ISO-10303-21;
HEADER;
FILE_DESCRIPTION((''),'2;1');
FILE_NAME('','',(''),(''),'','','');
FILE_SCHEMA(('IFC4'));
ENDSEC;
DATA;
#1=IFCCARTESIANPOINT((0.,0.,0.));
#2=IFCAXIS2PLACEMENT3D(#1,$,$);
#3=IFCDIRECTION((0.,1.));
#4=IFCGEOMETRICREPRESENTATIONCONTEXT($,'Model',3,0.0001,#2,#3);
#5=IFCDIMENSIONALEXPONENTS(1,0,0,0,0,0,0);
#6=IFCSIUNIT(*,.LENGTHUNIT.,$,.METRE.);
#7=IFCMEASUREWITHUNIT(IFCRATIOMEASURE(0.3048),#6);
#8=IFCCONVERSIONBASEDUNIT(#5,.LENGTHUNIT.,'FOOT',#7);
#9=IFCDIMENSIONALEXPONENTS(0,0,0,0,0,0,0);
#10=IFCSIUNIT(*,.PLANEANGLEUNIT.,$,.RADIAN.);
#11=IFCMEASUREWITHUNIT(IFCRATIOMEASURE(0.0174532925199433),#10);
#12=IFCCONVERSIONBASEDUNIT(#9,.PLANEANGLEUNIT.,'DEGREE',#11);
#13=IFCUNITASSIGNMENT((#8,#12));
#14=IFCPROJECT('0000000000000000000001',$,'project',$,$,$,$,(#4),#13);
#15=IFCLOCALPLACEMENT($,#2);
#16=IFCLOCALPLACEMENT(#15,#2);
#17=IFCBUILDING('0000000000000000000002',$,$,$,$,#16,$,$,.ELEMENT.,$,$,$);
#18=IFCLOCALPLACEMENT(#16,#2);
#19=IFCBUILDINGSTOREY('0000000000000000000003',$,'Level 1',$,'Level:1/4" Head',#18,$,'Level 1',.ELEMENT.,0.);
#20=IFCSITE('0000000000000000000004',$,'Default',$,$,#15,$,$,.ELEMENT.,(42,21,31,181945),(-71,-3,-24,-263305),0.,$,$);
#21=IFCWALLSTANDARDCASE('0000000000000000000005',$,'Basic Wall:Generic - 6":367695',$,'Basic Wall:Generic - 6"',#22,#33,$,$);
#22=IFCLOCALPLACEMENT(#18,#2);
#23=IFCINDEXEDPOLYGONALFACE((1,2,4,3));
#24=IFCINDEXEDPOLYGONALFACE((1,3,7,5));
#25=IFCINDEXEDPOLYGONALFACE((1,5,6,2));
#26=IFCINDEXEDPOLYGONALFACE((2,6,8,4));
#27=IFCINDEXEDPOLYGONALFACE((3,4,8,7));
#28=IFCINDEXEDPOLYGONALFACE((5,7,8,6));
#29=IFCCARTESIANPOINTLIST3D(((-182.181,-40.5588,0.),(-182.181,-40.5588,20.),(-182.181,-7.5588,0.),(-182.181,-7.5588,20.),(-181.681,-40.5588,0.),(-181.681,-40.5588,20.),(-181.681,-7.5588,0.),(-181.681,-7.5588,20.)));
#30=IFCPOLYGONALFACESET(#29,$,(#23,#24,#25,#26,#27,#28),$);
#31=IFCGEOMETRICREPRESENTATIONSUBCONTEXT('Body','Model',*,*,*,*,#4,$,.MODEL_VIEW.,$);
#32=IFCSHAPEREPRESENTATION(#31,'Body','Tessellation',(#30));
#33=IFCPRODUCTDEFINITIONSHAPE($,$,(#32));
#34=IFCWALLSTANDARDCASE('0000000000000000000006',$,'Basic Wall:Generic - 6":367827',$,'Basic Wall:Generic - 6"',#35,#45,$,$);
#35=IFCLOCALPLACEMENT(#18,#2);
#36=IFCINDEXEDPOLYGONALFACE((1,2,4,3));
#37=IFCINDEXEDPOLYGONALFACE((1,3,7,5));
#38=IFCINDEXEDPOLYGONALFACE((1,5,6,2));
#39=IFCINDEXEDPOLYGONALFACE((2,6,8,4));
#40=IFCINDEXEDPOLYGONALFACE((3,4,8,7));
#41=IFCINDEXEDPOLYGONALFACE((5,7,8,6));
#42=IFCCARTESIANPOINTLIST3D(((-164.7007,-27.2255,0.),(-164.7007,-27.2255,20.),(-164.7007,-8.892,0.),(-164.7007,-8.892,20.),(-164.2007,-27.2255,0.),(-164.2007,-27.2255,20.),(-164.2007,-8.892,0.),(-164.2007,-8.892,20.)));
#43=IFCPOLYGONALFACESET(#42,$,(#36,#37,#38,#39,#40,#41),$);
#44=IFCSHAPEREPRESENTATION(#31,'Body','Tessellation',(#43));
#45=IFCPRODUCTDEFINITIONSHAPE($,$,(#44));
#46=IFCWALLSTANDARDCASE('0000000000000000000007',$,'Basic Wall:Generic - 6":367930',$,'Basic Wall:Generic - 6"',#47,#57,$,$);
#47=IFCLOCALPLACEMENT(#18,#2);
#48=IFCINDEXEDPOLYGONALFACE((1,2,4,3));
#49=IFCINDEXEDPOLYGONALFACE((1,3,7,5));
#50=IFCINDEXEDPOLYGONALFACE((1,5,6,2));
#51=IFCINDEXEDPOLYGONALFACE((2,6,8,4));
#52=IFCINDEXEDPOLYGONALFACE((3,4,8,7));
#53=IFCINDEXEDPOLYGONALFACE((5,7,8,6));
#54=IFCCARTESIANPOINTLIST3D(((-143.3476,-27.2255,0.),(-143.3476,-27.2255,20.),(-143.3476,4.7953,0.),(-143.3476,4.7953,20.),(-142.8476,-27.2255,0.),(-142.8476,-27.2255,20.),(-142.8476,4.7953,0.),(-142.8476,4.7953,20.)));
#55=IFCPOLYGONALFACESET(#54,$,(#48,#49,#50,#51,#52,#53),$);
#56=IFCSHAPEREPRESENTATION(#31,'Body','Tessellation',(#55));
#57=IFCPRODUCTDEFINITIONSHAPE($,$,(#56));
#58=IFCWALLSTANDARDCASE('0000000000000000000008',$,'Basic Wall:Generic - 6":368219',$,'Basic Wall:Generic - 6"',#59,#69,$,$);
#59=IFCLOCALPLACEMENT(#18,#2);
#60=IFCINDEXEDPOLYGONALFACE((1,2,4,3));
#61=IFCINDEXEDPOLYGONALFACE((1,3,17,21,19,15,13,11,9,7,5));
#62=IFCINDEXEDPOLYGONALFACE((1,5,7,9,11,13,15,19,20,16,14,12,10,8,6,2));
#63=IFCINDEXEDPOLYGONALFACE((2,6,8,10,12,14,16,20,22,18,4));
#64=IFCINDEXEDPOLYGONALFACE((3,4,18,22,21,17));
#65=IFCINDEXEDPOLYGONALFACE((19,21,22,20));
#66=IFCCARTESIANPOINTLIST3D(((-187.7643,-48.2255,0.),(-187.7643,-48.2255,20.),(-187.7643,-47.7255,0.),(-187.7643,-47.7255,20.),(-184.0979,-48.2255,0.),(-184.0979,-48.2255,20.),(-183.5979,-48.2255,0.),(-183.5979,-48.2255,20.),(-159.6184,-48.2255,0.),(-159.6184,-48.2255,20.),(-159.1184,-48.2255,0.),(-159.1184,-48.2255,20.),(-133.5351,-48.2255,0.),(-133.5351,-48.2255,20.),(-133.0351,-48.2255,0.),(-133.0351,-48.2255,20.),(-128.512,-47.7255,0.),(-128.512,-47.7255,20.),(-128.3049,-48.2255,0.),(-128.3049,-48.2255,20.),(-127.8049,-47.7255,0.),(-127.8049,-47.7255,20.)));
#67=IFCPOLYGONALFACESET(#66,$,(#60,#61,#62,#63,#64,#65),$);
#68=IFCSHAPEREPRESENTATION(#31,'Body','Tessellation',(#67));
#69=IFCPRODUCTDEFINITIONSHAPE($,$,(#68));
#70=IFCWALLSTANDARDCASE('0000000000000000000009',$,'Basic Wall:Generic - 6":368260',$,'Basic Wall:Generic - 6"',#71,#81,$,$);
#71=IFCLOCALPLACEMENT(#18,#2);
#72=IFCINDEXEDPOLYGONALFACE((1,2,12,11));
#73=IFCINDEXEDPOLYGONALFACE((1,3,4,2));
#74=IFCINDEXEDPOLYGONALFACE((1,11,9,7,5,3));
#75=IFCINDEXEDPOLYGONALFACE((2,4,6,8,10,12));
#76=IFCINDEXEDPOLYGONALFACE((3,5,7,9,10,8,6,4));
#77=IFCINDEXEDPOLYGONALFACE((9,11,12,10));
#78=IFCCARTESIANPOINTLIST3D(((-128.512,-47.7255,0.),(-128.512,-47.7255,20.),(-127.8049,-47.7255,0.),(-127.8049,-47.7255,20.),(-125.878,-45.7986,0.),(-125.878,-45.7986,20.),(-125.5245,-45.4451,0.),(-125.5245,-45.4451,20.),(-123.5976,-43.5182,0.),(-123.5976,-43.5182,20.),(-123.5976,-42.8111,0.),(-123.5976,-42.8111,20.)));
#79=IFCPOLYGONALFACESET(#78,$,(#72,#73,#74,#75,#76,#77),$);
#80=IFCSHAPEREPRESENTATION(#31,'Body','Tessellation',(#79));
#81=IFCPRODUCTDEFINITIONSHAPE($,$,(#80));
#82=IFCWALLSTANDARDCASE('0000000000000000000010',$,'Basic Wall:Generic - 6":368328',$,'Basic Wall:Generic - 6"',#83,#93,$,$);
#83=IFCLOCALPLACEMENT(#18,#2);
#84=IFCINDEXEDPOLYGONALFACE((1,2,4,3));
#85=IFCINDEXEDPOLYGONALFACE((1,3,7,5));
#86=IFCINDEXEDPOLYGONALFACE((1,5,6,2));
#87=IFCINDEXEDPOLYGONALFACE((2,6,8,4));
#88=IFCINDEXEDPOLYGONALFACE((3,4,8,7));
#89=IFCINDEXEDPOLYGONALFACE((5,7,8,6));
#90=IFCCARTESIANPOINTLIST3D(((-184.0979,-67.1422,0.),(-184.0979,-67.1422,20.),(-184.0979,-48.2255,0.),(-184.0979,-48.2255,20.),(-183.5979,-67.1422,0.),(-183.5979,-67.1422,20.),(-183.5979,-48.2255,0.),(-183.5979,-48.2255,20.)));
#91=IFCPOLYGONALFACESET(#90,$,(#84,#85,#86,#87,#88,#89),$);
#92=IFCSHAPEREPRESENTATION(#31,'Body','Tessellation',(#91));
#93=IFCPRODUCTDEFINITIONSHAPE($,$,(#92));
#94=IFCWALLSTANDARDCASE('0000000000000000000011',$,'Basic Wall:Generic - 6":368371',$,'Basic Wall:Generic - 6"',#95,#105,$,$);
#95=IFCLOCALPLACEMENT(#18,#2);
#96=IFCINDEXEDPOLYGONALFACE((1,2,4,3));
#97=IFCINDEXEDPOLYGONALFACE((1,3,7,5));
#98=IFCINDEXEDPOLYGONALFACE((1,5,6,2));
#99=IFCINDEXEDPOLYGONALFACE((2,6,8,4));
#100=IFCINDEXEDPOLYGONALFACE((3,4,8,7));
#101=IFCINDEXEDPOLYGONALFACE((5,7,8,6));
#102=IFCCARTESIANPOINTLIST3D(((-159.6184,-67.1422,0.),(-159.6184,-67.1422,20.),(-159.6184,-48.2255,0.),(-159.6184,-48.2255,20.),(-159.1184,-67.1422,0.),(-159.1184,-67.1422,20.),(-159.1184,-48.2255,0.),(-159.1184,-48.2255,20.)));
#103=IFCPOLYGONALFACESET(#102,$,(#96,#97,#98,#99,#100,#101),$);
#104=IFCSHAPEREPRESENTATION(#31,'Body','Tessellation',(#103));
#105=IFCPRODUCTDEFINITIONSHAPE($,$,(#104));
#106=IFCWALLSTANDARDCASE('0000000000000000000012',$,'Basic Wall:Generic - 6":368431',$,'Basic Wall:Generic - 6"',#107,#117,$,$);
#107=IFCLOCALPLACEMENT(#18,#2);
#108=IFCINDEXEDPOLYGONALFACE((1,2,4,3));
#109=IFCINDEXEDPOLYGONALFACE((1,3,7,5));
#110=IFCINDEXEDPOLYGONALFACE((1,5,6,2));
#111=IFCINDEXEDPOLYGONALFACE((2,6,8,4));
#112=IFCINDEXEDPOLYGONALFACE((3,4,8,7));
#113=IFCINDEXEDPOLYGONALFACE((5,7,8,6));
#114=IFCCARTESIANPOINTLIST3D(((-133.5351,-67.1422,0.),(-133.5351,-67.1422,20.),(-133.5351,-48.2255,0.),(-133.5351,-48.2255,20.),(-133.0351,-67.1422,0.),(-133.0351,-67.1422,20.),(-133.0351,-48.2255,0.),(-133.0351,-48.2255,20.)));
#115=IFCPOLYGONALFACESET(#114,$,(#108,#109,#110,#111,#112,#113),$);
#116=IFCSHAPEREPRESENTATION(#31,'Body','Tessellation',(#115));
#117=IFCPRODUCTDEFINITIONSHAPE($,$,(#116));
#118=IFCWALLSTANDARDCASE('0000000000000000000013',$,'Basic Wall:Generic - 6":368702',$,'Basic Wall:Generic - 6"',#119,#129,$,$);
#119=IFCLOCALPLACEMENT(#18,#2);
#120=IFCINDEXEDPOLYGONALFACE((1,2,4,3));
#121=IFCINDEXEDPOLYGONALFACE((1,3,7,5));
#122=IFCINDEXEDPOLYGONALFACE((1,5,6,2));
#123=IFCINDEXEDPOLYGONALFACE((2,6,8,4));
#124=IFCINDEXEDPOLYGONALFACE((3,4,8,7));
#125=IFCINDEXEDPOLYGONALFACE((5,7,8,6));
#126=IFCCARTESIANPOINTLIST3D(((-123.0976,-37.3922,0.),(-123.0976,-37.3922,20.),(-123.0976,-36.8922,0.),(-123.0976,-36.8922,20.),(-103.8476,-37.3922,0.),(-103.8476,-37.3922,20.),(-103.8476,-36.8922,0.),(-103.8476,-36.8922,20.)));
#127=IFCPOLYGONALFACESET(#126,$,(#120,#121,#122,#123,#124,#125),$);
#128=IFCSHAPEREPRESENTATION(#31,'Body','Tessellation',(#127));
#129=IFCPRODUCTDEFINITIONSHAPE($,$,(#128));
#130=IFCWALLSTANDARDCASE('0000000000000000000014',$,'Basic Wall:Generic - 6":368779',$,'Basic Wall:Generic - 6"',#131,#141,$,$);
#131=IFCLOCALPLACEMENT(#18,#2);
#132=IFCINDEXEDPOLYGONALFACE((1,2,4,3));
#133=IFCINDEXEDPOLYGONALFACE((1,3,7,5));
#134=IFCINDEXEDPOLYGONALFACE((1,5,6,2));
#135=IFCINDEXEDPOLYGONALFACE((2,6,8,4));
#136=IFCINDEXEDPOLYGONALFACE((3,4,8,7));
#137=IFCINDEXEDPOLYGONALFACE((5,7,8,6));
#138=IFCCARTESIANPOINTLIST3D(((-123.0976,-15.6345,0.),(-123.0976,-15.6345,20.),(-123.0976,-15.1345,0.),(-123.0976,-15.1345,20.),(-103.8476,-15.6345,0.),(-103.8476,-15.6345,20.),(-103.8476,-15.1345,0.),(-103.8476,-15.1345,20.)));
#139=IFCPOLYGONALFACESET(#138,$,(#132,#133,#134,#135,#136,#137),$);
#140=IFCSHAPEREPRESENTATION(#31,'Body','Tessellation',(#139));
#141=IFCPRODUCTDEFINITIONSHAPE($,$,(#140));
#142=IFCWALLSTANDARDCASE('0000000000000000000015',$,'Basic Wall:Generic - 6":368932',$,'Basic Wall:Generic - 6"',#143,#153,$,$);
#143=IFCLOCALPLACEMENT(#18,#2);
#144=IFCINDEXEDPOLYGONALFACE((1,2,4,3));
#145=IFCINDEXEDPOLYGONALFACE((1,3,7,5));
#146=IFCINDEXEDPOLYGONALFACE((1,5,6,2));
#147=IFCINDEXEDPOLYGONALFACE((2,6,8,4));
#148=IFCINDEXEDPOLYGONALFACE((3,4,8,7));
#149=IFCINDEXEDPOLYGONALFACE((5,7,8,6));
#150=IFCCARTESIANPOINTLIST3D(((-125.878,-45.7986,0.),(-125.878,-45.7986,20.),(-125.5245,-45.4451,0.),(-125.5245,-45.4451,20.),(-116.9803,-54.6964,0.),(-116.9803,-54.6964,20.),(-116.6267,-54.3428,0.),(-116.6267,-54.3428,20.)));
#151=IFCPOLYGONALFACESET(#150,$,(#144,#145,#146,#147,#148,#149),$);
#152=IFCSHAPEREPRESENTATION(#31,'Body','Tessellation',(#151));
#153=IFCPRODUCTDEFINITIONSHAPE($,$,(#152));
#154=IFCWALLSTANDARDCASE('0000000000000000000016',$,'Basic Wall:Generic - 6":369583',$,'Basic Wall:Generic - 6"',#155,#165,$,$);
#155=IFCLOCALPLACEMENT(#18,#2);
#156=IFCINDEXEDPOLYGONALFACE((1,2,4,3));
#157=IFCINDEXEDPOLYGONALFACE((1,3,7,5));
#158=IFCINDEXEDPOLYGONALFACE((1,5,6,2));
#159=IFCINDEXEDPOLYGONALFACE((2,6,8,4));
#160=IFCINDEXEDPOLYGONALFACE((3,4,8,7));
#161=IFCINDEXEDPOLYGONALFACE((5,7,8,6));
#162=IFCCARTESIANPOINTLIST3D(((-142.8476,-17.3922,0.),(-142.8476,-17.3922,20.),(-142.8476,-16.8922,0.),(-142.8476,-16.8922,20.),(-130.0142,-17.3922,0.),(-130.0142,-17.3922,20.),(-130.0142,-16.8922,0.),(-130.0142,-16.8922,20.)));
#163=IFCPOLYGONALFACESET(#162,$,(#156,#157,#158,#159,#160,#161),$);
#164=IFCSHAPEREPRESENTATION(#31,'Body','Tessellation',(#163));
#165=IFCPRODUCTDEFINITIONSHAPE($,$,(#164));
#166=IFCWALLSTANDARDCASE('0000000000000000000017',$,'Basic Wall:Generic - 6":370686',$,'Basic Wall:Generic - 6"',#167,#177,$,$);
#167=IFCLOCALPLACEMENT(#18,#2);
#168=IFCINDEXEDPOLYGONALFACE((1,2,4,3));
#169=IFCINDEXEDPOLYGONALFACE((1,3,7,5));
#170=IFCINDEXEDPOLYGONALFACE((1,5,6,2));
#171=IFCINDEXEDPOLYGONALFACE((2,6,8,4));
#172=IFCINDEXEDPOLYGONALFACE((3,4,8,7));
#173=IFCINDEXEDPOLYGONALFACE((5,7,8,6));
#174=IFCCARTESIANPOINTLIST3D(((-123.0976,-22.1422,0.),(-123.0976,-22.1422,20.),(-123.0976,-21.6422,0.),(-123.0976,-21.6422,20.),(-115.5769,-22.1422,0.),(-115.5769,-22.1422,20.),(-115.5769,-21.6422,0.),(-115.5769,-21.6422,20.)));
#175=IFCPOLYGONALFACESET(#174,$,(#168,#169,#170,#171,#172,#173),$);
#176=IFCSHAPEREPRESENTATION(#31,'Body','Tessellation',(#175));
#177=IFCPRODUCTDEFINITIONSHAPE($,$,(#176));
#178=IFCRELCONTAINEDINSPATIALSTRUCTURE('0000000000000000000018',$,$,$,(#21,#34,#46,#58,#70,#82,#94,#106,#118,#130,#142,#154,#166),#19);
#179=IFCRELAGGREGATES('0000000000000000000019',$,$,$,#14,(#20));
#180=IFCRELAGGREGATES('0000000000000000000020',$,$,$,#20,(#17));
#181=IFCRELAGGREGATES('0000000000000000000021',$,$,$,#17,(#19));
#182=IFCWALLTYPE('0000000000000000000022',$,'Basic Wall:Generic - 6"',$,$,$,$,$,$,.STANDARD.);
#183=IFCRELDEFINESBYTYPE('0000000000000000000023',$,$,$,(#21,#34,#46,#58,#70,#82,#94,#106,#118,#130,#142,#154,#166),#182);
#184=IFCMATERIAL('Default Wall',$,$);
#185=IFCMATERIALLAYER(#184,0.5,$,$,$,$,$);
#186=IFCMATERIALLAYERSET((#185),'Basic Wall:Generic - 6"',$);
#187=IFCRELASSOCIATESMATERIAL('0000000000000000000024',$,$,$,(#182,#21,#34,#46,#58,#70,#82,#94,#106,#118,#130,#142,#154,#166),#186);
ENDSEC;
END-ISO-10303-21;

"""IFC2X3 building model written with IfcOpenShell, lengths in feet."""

from ifc_helpers import new_model, entity, si_unit, converted_unit, direction, frame, frame_2d, origin, place, context, subcontext, project, spatial, polyline, rectangle, outline, extrude, material, layer, layer_set, layer_usage, type_object, element, save


model = new_model("IFC2X3")

# Units and contexts
model_context = context("Model", 3, precision=0.0001, world=origin(), true_north=direction((0.0, 1.0)))
body_context = subcontext(model_context, "Body", "Model", "MODEL_VIEW")
ifc_project = project(units=[converted_unit("LENGTHUNIT", "FOOT", entity("IfcRatioMeasure", 0.3048), si_unit("LENGTHUNIT", "METRE"), dimensions=[1, 0, 0, 0, 0, 0, 0]), converted_unit("PLANEANGLEUNIT", "DEGREE", entity("IfcRatioMeasure", 0.0174532925199433), si_unit("PLANEANGLEUNIT", "RADIAN"), dimensions=[0, 0, 0, 0, 0, 0, 0])], contexts=[model_context])

# Site, building, storey
site_placement = place(None, origin())
site = spatial("IfcSite", under=ifc_project, at=site_placement, Name="Default", CompositionType="ELEMENT", RefLatitude=(42, 21, 31, 181945), RefLongitude=(-71, -3, -24, -263305), RefElevation=0.0)
building_placement = place(site_placement, origin())
building = spatial("IfcBuilding", under=site, at=building_placement, CompositionType="ELEMENT")
storey_placement = place(building_placement, origin())
storey = spatial("IfcBuildingStorey", under=building, at=storey_placement, Name="Level 1", ObjectType="Level:1/4\" Head", LongName="Level 1", CompositionType="ELEMENT", Elevation=0.0)

# Walls
ifc_material_1 = material(Name="Default Wall")
ifc_layer_1 = layer(ifc_material_1, 0.5)
ifc_layer_set_1 = layer_set([ifc_layer_1], Name="Basic Wall:Generic - 6\"")
wall_type_1 = type_object("IfcWallType", Name="Basic Wall:Generic - 6\"", PredefinedType="STANDARD", material=ifc_layer_set_1)
ifc_layer_usage_1 = layer_usage(ifc_layer_set_1, "AXIS2", "NEGATIVE", 0.25)
wall_1_placement = place(storey_placement, frame((-181.931, -40.5588, 0.0), z_axis=(0.0, 0.0, 1.0), x_axis=(0.0, 1.0, 0.0)))
element("IfcWallStandardCase", 1, at=wall_1_placement, inside=storey, type_object=wall_type_1, material=ifc_layer_usage_1, Name="Basic Wall:Generic - 6\":367695", ObjectType="Basic Wall:Generic - 6\"", context=body_context, shape_type="SweptSolid", body=[
    extrude(rectangle(XDim=33.0, YDim=0.5, at=frame_2d((16.5, 0.0), x_axis=(-1.0, 0.0))), origin(), (0.0, 0.0, 1.0), 20.0),
])
ifc_layer_usage_2 = layer_usage(ifc_layer_set_1, "AXIS2", "NEGATIVE", 0.25)
wall_2_placement = place(storey_placement, frame((-164.4507, -27.2255, 0.0), z_axis=(0.0, 0.0, 1.0), x_axis=(0.0, 1.0, 0.0)))
element("IfcWallStandardCase", 2, at=wall_2_placement, inside=storey, type_object=wall_type_1, material=ifc_layer_usage_2, Name="Basic Wall:Generic - 6\":367827", ObjectType="Basic Wall:Generic - 6\"", context=body_context, shape_type="SweptSolid", body=[
    extrude(rectangle(XDim=18.3335, YDim=0.5, at=frame_2d((9.1667, 0.0), x_axis=(-1.0, 0.0))), origin(), (0.0, 0.0, 1.0), 20.0),
])
ifc_layer_usage_3 = layer_usage(ifc_layer_set_1, "AXIS2", "NEGATIVE", 0.25)
wall_3_placement = place(storey_placement, frame((-143.0976, -27.2255, 0.0), z_axis=(0.0, 0.0, 1.0), x_axis=(0.0, 1.0, 0.0)))
element("IfcWallStandardCase", 3, at=wall_3_placement, inside=storey, type_object=wall_type_1, material=ifc_layer_usage_3, Name="Basic Wall:Generic - 6\":367930", ObjectType="Basic Wall:Generic - 6\"", context=body_context, shape_type="SweptSolid", body=[
    extrude(rectangle(XDim=32.0208, YDim=0.5, at=frame_2d((16.0104, 0.0), x_axis=(-1.0, 0.0))), origin(), (0.0, 0.0, 1.0), 20.0),
])
ifc_layer_usage_4 = layer_usage(ifc_layer_set_1, "AXIS2", "NEGATIVE", 0.25)
wall_4_placement = place(storey_placement, frame((-187.7643, -47.9755, 0.0)))
element("IfcWallStandardCase", 4, at=wall_4_placement, inside=storey, type_object=wall_type_1, material=ifc_layer_usage_4, Name="Basic Wall:Generic - 6\":368219", ObjectType="Basic Wall:Generic - 6\"", context=body_context, shape_type="SweptSolid", body=[
    extrude(outline(polyline([(59.4594, -0.25), (59.9594, 0.25), (59.2523, 0.25), (0.0, 0.25), (0.0, -0.25), (3.6664, -0.25), (4.1664, -0.25), (28.1459, -0.25), (28.6459, -0.25), (54.2292, -0.25), (54.7292, -0.25), (59.4594, -0.25)])), origin(), (0.0, 0.0, 1.0), 20.0),
])
ifc_layer_usage_5 = layer_usage(ifc_layer_set_1, "AXIS2", "NEGATIVE", 0.25)
wall_5_placement = place(storey_placement, frame((-128.3352, -47.9023, 0.0), z_axis=(0.0, 0.0, 1.0), x_axis=(0.707107, 0.707107, 0.0)))
element("IfcWallStandardCase", 5, at=wall_5_placement, inside=storey, type_object=wall_type_1, material=ifc_layer_usage_5, Name="Basic Wall:Generic - 6\":368260", ObjectType="Basic Wall:Generic - 6\"", context=body_context, shape_type="SweptSolid", body=[
    extrude(outline(polyline([(6.4499, -0.25), (6.9499, 0.25), (0.0, 0.25), (0.5, -0.25), (3.225, -0.25), (3.725, -0.25), (6.4499, -0.25)])), origin(), (0.0, 0.0, 1.0), 20.0),
])
ifc_layer_usage_6 = layer_usage(ifc_layer_set_1, "AXIS2", "NEGATIVE", 0.25)
wall_6_placement = place(storey_placement, frame((-183.8479, -48.2255, 0.0), z_axis=(0.0, 0.0, 1.0), x_axis=(0.0, -1.0, 0.0)))
element("IfcWallStandardCase", 6, at=wall_6_placement, inside=storey, type_object=wall_type_1, material=ifc_layer_usage_6, Name="Basic Wall:Generic - 6\":368328", ObjectType="Basic Wall:Generic - 6\"", context=body_context, shape_type="SweptSolid", body=[
    extrude(rectangle(XDim=18.9167, YDim=0.5, at=frame_2d((9.4583, 0.0), x_axis=(-1.0, 0.0))), origin(), (0.0, 0.0, 1.0), 20.0),
])
ifc_layer_usage_7 = layer_usage(ifc_layer_set_1, "AXIS2", "NEGATIVE", 0.25)
wall_7_placement = place(storey_placement, frame((-159.3684, -48.2255, 0.0), z_axis=(0.0, 0.0, 1.0), x_axis=(0.0, -1.0, 0.0)))
element("IfcWallStandardCase", 7, at=wall_7_placement, inside=storey, type_object=wall_type_1, material=ifc_layer_usage_7, Name="Basic Wall:Generic - 6\":368371", ObjectType="Basic Wall:Generic - 6\"", context=body_context, shape_type="SweptSolid", body=[
    extrude(rectangle(XDim=18.9167, YDim=0.5, at=frame_2d((9.4583, 0.0), x_axis=(-1.0, 0.0))), origin(), (0.0, 0.0, 1.0), 20.0),
])
ifc_layer_usage_8 = layer_usage(ifc_layer_set_1, "AXIS2", "NEGATIVE", 0.25)
wall_8_placement = place(storey_placement, frame((-133.2851, -48.2255, 0.0), z_axis=(0.0, 0.0, 1.0), x_axis=(0.0, -1.0, 0.0)))
element("IfcWallStandardCase", 8, at=wall_8_placement, inside=storey, type_object=wall_type_1, material=ifc_layer_usage_8, Name="Basic Wall:Generic - 6\":368431", ObjectType="Basic Wall:Generic - 6\"", context=body_context, shape_type="SweptSolid", body=[
    extrude(rectangle(XDim=18.9167, YDim=0.5, at=frame_2d((9.4583, 0.0), x_axis=(-1.0, 0.0))), origin(), (0.0, 0.0, 1.0), 20.0),
])
ifc_layer_usage_9 = layer_usage(ifc_layer_set_1, "AXIS2", "NEGATIVE", 0.25)
wall_9_placement = place(storey_placement, frame((-103.8476, -37.1422, 0.0), z_axis=(0.0, 0.0, 1.0), x_axis=(-1.0, 0.0, 0.0)))
element("IfcWallStandardCase", 9, at=wall_9_placement, inside=storey, type_object=wall_type_1, material=ifc_layer_usage_9, Name="Basic Wall:Generic - 6\":368702", ObjectType="Basic Wall:Generic - 6\"", context=body_context, shape_type="SweptSolid", body=[
    extrude(rectangle(XDim=19.25, YDim=0.5, at=frame_2d((9.625, 0.0), x_axis=(-1.0, 0.0))), origin(), (0.0, 0.0, 1.0), 20.0),
])
ifc_layer_usage_10 = layer_usage(ifc_layer_set_1, "AXIS2", "NEGATIVE", 0.25)
wall_10_placement = place(storey_placement, frame((-103.8476, -15.3845, 0.0), z_axis=(0.0, 0.0, 1.0), x_axis=(-1.0, 0.0, 0.0)))
element("IfcWallStandardCase", 10, at=wall_10_placement, inside=storey, type_object=wall_type_1, material=ifc_layer_usage_10, Name="Basic Wall:Generic - 6\":368779", ObjectType="Basic Wall:Generic - 6\"", context=body_context, shape_type="SweptSolid", body=[
    extrude(rectangle(XDim=19.25, YDim=0.5, at=frame_2d((9.625, 0.0), x_axis=(-1.0, 0.0))), origin(), (0.0, 0.0, 1.0), 20.0),
])
ifc_layer_usage_11 = layer_usage(ifc_layer_set_1, "AXIS2", "NEGATIVE", 0.25)
wall_11_placement = place(storey_placement, frame((-125.7013, -45.6219, 0.0), z_axis=(0.0, 0.0, 1.0), x_axis=(0.707107, -0.707107, 0.0)))
element("IfcWallStandardCase", 11, at=wall_11_placement, inside=storey, type_object=wall_type_1, material=ifc_layer_usage_11, Name="Basic Wall:Generic - 6\":368932", ObjectType="Basic Wall:Generic - 6\"", context=body_context, shape_type="SweptSolid", body=[
    extrude(rectangle(XDim=12.5833, YDim=0.5, at=frame_2d((6.2917, 0.0), x_axis=(-1.0, 0.0))), origin(), (0.0, 0.0, 1.0), 20.0),
])
ifc_layer_usage_12 = layer_usage(ifc_layer_set_1, "AXIS2", "NEGATIVE", 0.25)
wall_12_placement = place(storey_placement, frame((-142.8476, -17.1422, 0.0)))
element("IfcWallStandardCase", 12, at=wall_12_placement, inside=storey, type_object=wall_type_1, material=ifc_layer_usage_12, Name="Basic Wall:Generic - 6\":369583", ObjectType="Basic Wall:Generic - 6\"", context=body_context, shape_type="SweptSolid", body=[
    extrude(rectangle(XDim=12.8333, YDim=0.5, at=frame_2d((6.4167, 0.0), x_axis=(-1.0, 0.0))), origin(), (0.0, 0.0, 1.0), 20.0),
])
ifc_layer_usage_13 = layer_usage(ifc_layer_set_1, "AXIS2", "NEGATIVE", 0.25)
wall_13_placement = place(storey_placement, frame((-123.0976, -21.8922, 0.0)))
element("IfcWallStandardCase", 13, at=wall_13_placement, inside=storey, type_object=wall_type_1, material=ifc_layer_usage_13, Name="Basic Wall:Generic - 6\":370686", ObjectType="Basic Wall:Generic - 6\"", context=body_context, shape_type="SweptSolid", body=[
    extrude(rectangle(XDim=7.5208, YDim=0.5, at=frame_2d((3.7604, 0.0), x_axis=(-1.0, 0.0))), origin(), (0.0, 0.0, 1.0), 20.0),
])

save(model, "model.ifc")
